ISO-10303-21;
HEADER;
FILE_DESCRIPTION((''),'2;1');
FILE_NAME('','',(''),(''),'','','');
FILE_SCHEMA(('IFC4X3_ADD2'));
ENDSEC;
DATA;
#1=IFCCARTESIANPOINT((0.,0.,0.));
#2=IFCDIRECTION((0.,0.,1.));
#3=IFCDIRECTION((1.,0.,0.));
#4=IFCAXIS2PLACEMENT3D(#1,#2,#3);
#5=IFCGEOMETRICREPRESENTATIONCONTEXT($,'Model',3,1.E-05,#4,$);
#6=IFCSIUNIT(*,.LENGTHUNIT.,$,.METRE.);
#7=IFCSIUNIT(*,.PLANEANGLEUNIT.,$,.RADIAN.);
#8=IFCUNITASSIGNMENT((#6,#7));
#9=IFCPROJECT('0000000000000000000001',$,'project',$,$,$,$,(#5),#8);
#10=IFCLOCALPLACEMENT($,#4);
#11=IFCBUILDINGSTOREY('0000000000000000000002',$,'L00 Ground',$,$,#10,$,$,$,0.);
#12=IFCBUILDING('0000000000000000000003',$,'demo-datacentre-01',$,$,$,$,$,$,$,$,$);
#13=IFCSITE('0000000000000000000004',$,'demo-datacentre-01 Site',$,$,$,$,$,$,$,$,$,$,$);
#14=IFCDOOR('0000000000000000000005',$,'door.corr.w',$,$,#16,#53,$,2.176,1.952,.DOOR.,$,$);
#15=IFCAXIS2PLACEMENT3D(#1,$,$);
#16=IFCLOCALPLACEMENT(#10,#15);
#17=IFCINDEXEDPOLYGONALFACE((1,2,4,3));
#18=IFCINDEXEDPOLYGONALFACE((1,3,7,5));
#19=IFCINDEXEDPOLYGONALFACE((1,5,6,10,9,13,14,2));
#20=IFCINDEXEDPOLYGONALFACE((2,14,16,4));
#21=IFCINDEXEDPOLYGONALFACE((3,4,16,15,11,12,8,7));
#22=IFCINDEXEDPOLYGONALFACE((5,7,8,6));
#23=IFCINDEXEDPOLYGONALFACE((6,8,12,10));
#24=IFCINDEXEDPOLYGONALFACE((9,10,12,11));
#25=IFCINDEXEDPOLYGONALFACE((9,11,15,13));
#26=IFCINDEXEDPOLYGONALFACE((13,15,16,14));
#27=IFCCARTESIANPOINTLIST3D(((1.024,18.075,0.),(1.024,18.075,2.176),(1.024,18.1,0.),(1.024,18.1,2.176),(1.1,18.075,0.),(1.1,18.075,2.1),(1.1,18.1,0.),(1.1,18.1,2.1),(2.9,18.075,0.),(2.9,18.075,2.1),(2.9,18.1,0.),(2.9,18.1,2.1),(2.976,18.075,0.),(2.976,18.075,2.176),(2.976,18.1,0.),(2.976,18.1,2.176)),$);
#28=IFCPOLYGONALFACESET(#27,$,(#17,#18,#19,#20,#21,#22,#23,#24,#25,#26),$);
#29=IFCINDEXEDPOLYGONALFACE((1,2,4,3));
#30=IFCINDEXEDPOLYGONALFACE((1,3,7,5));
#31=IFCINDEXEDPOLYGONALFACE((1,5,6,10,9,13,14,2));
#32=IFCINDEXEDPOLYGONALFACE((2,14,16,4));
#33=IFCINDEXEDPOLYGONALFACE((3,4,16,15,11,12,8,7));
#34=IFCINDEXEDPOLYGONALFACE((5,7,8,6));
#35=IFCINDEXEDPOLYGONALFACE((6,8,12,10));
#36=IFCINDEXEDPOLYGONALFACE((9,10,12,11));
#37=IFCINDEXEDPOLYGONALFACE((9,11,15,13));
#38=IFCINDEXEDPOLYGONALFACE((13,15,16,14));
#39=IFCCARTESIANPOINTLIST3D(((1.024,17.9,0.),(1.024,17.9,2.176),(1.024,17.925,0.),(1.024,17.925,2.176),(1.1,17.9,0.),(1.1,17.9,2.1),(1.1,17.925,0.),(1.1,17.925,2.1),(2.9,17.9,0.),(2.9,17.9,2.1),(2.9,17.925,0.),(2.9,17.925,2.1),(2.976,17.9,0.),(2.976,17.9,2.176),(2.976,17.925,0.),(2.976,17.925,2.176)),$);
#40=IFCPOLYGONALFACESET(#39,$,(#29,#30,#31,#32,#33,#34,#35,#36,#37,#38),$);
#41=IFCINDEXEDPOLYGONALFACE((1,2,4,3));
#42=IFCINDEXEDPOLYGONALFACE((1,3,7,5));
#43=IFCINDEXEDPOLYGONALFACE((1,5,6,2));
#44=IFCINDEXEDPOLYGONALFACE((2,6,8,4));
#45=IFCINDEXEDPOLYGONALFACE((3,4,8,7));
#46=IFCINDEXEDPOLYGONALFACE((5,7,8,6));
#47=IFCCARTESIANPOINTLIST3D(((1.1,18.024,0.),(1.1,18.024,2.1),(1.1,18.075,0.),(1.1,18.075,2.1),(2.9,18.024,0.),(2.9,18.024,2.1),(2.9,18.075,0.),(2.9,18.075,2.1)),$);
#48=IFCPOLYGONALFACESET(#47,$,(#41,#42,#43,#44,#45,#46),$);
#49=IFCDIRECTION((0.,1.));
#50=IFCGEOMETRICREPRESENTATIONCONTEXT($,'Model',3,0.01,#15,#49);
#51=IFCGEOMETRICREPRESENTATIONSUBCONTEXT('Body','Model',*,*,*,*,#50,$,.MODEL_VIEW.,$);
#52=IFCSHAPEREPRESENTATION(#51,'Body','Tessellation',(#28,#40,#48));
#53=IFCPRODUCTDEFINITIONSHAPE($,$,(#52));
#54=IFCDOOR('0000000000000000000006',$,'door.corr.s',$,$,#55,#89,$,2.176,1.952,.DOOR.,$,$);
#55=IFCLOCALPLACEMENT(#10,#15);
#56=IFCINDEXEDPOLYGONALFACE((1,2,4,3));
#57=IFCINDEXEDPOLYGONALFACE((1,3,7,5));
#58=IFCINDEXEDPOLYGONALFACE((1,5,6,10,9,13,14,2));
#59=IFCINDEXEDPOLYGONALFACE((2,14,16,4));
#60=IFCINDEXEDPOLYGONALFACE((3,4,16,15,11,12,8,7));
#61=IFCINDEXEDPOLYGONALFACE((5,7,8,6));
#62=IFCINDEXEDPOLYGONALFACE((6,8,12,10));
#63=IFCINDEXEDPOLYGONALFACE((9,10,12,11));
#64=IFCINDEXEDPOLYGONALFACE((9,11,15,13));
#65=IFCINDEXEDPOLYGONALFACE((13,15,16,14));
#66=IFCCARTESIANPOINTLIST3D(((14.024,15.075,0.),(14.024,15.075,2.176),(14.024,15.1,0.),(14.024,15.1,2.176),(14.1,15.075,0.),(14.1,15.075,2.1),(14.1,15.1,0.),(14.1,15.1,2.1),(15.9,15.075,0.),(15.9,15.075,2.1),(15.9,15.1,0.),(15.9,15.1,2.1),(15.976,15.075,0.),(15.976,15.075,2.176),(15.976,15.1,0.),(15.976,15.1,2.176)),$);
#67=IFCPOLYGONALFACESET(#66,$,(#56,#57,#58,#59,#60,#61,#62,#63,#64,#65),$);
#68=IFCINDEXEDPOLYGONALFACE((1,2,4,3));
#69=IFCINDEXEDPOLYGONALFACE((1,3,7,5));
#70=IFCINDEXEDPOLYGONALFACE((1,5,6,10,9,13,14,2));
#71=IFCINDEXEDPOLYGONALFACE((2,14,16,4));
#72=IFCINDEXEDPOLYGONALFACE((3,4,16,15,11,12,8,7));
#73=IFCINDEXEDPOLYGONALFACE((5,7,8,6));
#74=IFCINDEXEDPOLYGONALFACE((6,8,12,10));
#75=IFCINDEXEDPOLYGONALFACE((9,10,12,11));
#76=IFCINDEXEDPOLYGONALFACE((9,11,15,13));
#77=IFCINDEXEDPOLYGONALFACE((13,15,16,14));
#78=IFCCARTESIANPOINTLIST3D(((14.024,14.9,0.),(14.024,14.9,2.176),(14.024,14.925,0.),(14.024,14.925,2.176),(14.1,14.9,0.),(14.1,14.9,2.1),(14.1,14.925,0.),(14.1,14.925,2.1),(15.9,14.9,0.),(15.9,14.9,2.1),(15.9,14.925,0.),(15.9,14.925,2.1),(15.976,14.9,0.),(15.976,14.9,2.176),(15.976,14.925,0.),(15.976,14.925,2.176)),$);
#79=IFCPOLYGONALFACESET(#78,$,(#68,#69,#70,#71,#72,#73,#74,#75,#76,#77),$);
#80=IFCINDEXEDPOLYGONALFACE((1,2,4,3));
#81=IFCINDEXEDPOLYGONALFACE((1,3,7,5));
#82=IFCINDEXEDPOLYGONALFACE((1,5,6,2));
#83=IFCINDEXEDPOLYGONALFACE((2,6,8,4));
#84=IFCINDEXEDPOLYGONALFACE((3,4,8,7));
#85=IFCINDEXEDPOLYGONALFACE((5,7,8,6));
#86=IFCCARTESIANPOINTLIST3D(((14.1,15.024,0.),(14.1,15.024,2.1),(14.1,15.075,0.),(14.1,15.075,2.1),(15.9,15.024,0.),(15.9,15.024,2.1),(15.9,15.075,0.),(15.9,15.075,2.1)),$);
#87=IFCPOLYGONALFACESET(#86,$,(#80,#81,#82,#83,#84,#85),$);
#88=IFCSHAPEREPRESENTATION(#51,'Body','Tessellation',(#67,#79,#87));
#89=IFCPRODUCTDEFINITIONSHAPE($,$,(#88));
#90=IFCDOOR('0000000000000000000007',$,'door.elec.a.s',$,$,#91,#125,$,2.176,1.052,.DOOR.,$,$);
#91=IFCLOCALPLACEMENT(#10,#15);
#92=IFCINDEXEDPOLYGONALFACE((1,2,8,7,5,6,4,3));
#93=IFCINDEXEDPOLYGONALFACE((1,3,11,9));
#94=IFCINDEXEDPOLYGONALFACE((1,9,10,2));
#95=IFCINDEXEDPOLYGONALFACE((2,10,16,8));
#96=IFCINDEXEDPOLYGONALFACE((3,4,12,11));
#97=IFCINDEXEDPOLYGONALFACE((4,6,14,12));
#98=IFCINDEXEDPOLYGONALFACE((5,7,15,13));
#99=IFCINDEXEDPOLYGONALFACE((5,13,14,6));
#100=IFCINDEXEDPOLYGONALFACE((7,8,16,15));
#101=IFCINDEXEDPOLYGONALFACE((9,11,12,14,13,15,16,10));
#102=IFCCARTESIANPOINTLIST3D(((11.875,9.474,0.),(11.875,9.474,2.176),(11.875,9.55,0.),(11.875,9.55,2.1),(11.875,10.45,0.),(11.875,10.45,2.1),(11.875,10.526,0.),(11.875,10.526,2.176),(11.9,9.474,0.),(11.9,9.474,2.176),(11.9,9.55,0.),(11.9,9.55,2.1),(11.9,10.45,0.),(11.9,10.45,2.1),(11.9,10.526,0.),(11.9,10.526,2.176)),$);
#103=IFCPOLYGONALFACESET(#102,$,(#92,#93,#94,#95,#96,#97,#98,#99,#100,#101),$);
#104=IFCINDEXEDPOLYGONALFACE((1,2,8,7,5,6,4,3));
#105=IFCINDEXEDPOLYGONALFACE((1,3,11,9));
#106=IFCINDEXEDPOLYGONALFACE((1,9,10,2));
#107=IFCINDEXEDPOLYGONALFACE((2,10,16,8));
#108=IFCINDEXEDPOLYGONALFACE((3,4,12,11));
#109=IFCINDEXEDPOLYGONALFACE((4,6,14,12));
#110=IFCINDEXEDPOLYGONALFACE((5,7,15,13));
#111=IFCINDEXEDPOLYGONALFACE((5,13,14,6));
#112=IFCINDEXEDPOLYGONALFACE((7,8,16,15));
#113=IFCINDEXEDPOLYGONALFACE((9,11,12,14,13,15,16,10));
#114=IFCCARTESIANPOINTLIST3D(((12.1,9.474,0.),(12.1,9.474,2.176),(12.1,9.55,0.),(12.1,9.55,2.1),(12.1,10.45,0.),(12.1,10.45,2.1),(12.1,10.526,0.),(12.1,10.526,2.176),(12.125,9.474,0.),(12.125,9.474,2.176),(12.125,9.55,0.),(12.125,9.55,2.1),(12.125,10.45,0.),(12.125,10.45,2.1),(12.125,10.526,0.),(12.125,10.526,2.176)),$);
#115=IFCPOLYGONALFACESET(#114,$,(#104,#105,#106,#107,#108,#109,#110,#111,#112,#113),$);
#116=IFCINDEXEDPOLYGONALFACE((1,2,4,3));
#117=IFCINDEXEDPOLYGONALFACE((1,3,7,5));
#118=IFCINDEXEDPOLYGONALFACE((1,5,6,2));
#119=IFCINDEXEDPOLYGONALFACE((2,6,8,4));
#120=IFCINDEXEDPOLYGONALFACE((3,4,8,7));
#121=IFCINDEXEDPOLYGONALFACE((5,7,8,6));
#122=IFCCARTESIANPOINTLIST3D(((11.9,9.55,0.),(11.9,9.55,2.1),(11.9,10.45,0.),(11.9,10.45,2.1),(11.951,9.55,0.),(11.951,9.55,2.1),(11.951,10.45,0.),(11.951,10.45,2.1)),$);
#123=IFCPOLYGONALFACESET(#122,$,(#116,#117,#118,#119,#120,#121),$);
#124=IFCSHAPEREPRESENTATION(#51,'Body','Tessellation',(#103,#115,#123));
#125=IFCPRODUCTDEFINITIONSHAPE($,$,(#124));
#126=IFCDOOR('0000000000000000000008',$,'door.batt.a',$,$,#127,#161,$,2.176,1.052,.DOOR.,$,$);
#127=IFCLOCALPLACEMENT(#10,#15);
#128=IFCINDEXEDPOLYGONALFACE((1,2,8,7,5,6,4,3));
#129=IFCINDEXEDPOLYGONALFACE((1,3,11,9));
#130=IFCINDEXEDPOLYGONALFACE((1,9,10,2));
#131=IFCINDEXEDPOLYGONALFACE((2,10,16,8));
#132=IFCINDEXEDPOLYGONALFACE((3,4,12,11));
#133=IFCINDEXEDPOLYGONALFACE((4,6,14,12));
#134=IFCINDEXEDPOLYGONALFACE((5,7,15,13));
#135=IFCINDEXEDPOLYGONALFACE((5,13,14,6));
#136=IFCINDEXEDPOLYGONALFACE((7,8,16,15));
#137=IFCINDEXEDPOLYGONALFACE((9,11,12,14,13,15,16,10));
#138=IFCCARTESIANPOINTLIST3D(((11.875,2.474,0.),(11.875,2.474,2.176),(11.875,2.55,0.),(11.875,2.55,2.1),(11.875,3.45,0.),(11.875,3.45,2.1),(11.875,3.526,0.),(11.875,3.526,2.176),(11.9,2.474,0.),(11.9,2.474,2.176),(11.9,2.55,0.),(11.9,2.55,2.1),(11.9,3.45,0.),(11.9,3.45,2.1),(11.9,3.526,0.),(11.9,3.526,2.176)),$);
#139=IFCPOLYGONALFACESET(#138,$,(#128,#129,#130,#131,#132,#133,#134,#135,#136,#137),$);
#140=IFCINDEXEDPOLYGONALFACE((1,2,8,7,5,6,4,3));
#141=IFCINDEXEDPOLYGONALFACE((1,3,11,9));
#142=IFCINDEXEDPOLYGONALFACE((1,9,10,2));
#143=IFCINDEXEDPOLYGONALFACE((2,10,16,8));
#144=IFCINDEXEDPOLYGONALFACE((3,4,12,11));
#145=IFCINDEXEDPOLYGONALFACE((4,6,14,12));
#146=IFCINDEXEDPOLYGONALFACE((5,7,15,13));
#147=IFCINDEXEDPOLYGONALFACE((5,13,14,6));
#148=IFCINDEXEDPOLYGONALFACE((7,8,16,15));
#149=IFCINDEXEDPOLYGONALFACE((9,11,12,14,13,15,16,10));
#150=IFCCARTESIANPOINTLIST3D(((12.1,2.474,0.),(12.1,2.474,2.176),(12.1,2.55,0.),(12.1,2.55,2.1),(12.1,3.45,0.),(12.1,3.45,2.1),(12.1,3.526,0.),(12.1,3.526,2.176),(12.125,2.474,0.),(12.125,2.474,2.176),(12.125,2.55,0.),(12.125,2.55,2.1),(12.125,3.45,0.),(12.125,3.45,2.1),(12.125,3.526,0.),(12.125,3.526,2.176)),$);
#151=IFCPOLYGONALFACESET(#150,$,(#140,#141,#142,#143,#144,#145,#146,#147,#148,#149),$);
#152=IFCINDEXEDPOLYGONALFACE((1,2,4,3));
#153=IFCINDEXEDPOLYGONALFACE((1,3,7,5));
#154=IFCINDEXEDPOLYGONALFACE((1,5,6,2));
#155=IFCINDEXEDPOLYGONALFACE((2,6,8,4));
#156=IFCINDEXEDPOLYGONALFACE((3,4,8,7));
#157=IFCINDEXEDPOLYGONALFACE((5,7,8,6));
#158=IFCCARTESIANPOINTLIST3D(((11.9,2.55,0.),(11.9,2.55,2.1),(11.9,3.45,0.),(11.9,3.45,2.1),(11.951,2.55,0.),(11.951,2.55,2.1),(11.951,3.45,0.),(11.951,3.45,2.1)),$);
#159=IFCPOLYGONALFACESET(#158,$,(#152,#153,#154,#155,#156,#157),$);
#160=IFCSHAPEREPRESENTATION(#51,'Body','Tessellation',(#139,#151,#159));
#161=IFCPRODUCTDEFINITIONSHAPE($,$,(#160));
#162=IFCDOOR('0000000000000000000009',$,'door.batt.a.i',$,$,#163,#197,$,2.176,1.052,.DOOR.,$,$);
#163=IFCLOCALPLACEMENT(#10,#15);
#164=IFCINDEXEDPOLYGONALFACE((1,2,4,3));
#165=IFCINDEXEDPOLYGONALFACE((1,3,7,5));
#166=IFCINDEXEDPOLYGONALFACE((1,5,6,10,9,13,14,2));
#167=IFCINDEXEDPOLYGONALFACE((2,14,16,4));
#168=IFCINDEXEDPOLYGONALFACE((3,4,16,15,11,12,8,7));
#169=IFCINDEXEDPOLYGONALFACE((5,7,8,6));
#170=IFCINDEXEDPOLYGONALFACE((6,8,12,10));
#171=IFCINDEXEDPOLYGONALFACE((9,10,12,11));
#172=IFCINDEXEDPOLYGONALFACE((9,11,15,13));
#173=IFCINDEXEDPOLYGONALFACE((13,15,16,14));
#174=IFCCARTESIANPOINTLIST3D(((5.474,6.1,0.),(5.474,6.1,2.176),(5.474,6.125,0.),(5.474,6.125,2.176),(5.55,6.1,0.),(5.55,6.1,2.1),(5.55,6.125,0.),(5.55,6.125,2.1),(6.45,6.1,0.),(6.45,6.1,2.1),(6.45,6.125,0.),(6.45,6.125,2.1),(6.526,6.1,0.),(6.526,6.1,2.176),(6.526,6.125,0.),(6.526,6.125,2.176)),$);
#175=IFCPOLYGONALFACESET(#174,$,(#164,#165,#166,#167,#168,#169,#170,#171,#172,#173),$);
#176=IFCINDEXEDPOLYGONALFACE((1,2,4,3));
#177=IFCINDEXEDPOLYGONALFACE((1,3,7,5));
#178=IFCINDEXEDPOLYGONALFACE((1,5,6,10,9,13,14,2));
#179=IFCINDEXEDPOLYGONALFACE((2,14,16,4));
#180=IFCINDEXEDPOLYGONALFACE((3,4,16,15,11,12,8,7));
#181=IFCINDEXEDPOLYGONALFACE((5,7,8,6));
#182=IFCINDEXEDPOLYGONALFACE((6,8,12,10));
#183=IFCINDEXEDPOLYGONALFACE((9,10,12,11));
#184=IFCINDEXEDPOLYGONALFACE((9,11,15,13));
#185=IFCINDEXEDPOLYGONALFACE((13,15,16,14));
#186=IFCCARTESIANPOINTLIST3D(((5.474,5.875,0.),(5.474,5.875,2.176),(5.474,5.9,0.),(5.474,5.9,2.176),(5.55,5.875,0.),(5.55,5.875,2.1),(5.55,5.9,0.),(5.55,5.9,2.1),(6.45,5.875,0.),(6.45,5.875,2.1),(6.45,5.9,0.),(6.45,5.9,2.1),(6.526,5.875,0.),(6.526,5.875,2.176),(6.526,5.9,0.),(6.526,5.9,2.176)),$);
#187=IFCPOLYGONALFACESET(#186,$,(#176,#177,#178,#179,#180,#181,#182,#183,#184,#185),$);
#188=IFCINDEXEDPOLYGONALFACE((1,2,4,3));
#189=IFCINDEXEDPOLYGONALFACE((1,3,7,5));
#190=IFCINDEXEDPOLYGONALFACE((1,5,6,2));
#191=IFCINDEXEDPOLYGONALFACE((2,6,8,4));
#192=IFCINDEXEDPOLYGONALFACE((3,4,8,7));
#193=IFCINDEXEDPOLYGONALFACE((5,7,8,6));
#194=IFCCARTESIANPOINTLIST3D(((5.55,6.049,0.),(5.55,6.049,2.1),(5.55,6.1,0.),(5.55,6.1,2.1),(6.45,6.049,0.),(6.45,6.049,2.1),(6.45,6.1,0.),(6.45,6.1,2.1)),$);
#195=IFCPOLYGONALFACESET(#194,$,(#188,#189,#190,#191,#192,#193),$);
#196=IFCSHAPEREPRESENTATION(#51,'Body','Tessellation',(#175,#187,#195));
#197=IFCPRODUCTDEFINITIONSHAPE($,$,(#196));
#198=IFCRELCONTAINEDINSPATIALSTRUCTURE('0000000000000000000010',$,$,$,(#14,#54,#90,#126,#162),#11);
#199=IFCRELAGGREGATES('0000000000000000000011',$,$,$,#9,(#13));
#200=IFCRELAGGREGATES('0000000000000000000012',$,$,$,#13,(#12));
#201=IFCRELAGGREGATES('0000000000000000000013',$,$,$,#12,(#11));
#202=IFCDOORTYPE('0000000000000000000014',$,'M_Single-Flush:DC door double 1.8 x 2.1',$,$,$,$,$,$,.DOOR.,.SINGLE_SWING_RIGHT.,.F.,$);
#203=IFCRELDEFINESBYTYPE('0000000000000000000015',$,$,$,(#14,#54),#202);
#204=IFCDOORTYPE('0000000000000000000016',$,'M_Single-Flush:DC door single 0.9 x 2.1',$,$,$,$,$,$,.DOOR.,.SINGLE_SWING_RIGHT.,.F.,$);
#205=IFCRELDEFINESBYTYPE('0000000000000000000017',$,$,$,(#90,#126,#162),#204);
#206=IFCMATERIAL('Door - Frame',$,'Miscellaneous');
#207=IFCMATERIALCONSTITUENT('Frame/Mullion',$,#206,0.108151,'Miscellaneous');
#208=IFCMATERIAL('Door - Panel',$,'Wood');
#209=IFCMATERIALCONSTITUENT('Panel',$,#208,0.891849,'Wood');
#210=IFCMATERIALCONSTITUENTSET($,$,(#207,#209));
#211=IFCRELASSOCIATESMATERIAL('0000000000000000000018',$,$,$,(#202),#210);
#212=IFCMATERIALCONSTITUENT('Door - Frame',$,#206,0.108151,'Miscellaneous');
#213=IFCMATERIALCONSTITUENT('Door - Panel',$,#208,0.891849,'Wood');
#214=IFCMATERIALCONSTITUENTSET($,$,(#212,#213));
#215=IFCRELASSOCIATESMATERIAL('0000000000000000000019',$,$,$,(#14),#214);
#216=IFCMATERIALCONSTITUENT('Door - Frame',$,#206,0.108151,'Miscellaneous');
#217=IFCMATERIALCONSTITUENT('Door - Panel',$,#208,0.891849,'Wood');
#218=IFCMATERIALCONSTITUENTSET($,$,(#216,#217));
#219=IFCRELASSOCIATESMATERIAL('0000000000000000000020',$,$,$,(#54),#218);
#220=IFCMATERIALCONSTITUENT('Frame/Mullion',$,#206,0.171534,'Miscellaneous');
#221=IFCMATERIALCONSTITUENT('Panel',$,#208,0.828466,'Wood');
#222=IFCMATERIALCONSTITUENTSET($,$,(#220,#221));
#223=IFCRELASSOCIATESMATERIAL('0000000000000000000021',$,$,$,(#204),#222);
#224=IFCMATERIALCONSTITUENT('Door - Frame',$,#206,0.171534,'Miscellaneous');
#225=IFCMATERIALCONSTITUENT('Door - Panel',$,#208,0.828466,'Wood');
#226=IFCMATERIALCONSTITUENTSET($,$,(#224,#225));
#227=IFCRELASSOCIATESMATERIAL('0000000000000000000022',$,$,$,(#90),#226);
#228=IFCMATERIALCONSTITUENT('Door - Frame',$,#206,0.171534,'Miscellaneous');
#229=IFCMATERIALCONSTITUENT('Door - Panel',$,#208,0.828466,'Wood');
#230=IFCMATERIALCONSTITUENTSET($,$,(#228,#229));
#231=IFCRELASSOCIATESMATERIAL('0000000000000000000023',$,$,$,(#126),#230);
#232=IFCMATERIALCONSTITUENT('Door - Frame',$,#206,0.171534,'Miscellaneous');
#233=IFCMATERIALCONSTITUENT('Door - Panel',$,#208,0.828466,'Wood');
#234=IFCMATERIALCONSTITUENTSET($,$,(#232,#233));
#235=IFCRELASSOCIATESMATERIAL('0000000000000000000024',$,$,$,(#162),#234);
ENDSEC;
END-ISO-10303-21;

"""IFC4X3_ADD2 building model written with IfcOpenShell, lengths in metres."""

from ifc_helpers import new_model, si_unit, direction, frame, frame_2d, origin, origin_with_axes, place, context, subcontext, project, spatial, polyline, rectangle, outline, extrude, source, transform, mapped, material, constituent, constituent_set, type_object, type_shapes, element, save


model = new_model("IFC4X3_ADD2")

# Units and contexts
model_context_1 = context("Model", 3, precision=0.01, world=origin(), true_north=direction((0.0, 1.0)))
model_context_2 = context("Model", 3, precision=1e-05, world=origin_with_axes())
body_context = subcontext(model_context_1, "Body", "Model", "MODEL_VIEW")
ifc_project = project(units=[si_unit("LENGTHUNIT", "METRE"), si_unit("PLANEANGLEUNIT", "RADIAN")], contexts=[model_context_2])

# Site, building, storey
site = spatial("IfcSite", under=ifc_project, Name="demo-datacentre-01 Site")
building = spatial("IfcBuilding", under=site, Name="demo-datacentre-01")
storey_placement = place(None, origin_with_axes())
storey = spatial("IfcBuildingStorey", under=building, at=storey_placement, Name="L00 Ground", Elevation=0.0)

# Shared definitions
placement_1 = place(None, origin())
placement_2 = place(placement_1, origin())
placement_3 = place(placement_2, origin())

# Doors
ifc_material_1 = material(Name="Door - Frame", Category="Miscellaneous")
ifc_material_2 = material(Name="Door - Panel", Category="Wood")
ifc_constituent_1 = constituent(ifc_material_1, Name="Door - Frame", Category="Miscellaneous", fraction=0.108151)
ifc_constituent_2 = constituent(ifc_material_2, Name="Door - Panel", Category="Wood", fraction=0.891849)
ifc_constituent_set_1 = constituent_set(constituents=[ifc_constituent_1, ifc_constituent_2])
ifc_constituent_3 = constituent(ifc_material_1, Name="Frame/Mullion", Category="Miscellaneous", fraction=0.108151)
ifc_constituent_4 = constituent(ifc_material_2, Name="Panel", Category="Wood", fraction=0.891849)
ifc_constituent_set_2 = constituent_set(constituents=[ifc_constituent_3, ifc_constituent_4])
door_type_1 = type_object("IfcDoorType", Name="M_Single-Flush:DC door double 1.8 x 2.1", OperationType="SINGLE_SWING_RIGHT", ParameterTakesPrecedence=False, PredefinedType="DOOR", material=ifc_constituent_set_2)
shared_shape_1 = source(origin(), body_context, "Body", "SweptSolid", [
    extrude(outline(polyline([(-0.976, -1.107), (0.976, -1.107), (0.976, 1.069), (0.9, 1.069), (0.9, -1.031), (-0.9, -1.031), (-0.9, 1.069), (-0.976, 1.069), (-0.976, -1.107)])), frame((0.9, 0.15, 1.069), z_axis=(0.0, 1.0, 0.0), x_axis=(1.0, 0.0, 0.0)), (0.0, 0.0, 1.0), 0.025),
    extrude(outline(polyline([(-1.107, -0.976), (1.069, -0.976), (1.069, -0.9), (-1.031, -0.9), (-1.031, 0.9), (1.069, 0.9), (1.069, 0.976), (-1.107, 0.976), (-1.107, -0.976)])), frame((0.9, -0.025, 1.069), z_axis=(0.0, 1.0, 0.0), x_axis=(0.0, 0.0, -1.0)), (0.0, 0.0, 1.0), 0.025),
    extrude(rectangle(XDim=0.051, YDim=1.8, at=frame_2d((0.0, 0.0), x_axis=(1.0, 0.0))), frame((0.9, 0.1245, 0.0), z_axis=(0.0, 0.0, 1.0), x_axis=(0.0, 1.0, 0.0)), (0.0, 0.0, 1.0), 2.1),
])
type_shapes(door_type_1, [shared_shape_1])
door_1_placement = place(placement_3, frame((1.1, 17.925, 0.0)))
element("IfcDoor", 1, at=door_1_placement, inside=storey, type_object=door_type_1, material=ifc_constituent_set_1, Name="door.corr.w", OverallHeight=2.176, OverallWidth=1.952, PredefinedType="DOOR", context=body_context, shape_type="MappedRepresentation", body=[
    mapped(shared_shape_1, transform((0.0, 0.0, 0.0), scale=1.0)),
])
ifc_constituent_5 = constituent(ifc_material_1, Name="Door - Frame", Category="Miscellaneous", fraction=0.108151)
ifc_constituent_6 = constituent(ifc_material_2, Name="Door - Panel", Category="Wood", fraction=0.891849)
ifc_constituent_set_3 = constituent_set(constituents=[ifc_constituent_5, ifc_constituent_6])
door_2_placement = place(placement_3, frame((14.1, 14.925, 0.0)))
element("IfcDoor", 2, at=door_2_placement, inside=storey, type_object=door_type_1, material=ifc_constituent_set_3, Name="door.corr.s", OverallHeight=2.176, OverallWidth=1.952, PredefinedType="DOOR", context=body_context, shape_type="MappedRepresentation", body=[
    mapped(shared_shape_1, transform((0.0, 0.0, 0.0), scale=1.0)),
])
ifc_constituent_7 = constituent(ifc_material_1, Name="Door - Frame", Category="Miscellaneous", fraction=0.171534)
ifc_constituent_8 = constituent(ifc_material_2, Name="Door - Panel", Category="Wood", fraction=0.828466)
ifc_constituent_set_4 = constituent_set(constituents=[ifc_constituent_7, ifc_constituent_8])
ifc_constituent_9 = constituent(ifc_material_1, Name="Frame/Mullion", Category="Miscellaneous", fraction=0.171534)
ifc_constituent_10 = constituent(ifc_material_2, Name="Panel", Category="Wood", fraction=0.828466)
ifc_constituent_set_5 = constituent_set(constituents=[ifc_constituent_9, ifc_constituent_10])
door_type_2 = type_object("IfcDoorType", Name="M_Single-Flush:DC door single 0.9 x 2.1", OperationType="SINGLE_SWING_RIGHT", ParameterTakesPrecedence=False, PredefinedType="DOOR", material=ifc_constituent_set_5)
shared_shape_2 = source(origin(), body_context, "Body", "SweptSolid", [
    extrude(outline(polyline([(-0.526, -1.107), (0.526, -1.107), (0.526, 1.069), (0.45, 1.069), (0.45, -1.031), (-0.45, -1.031), (-0.45, 1.069), (-0.526, 1.069), (-0.526, -1.107)])), frame((0.45, 0.2, 1.069), z_axis=(0.0, 1.0, 0.0), x_axis=(1.0, 0.0, 0.0)), (0.0, 0.0, 1.0), 0.025),
    extrude(outline(polyline([(-1.107, -0.526), (1.069, -0.526), (1.069, -0.45), (-1.031, -0.45), (-1.031, 0.45), (1.069, 0.45), (1.069, 0.526), (-1.107, 0.526), (-1.107, -0.526)])), frame((0.45, -0.025, 1.069), z_axis=(0.0, 1.0, 0.0), x_axis=(0.0, 0.0, -1.0)), (0.0, 0.0, 1.0), 0.025),
    extrude(rectangle(XDim=0.051, YDim=0.9, at=frame_2d((0.0, 0.0), x_axis=(1.0, 0.0))), frame((0.45, 0.1745, 0.0), z_axis=(0.0, 0.0, 1.0), x_axis=(0.0, 1.0, 0.0)), (0.0, 0.0, 1.0), 2.1),
])
type_shapes(door_type_2, [shared_shape_2])
door_3_placement = place(placement_3, frame((12.1, 9.55, 0.0), z_axis=(0.0, 0.0, 1.0), x_axis=(0.0, 1.0, 0.0)))
element("IfcDoor", 3, at=door_3_placement, inside=storey, type_object=door_type_2, material=ifc_constituent_set_4, Name="door.elec.a.s", OverallHeight=2.176, OverallWidth=1.052, PredefinedType="DOOR", context=body_context, shape_type="MappedRepresentation", body=[
    mapped(shared_shape_2, transform((0.0, 0.0, 0.0), scale=1.0)),
])
ifc_constituent_11 = constituent(ifc_material_1, Name="Door - Frame", Category="Miscellaneous", fraction=0.171534)
ifc_constituent_12 = constituent(ifc_material_2, Name="Door - Panel", Category="Wood", fraction=0.828466)
ifc_constituent_set_6 = constituent_set(constituents=[ifc_constituent_11, ifc_constituent_12])
door_4_placement = place(placement_3, frame((12.1, 2.55, 0.0), z_axis=(0.0, 0.0, 1.0), x_axis=(0.0, 1.0, 0.0)))
element("IfcDoor", 4, at=door_4_placement, inside=storey, type_object=door_type_2, material=ifc_constituent_set_6, Name="door.batt.a", OverallHeight=2.176, OverallWidth=1.052, PredefinedType="DOOR", context=body_context, shape_type="MappedRepresentation", body=[
    mapped(shared_shape_2, transform((0.0, 0.0, 0.0), scale=1.0)),
])
ifc_constituent_13 = constituent(ifc_material_1, Name="Door - Frame", Category="Miscellaneous", fraction=0.171534)
ifc_constituent_14 = constituent(ifc_material_2, Name="Door - Panel", Category="Wood", fraction=0.828466)
ifc_constituent_set_7 = constituent_set(constituents=[ifc_constituent_13, ifc_constituent_14])
door_5_placement = place(placement_3, frame((5.55, 5.9, 0.0)))
element("IfcDoor", 5, at=door_5_placement, inside=storey, type_object=door_type_2, material=ifc_constituent_set_7, Name="door.batt.a.i", OverallHeight=2.176, OverallWidth=1.052, PredefinedType="DOOR", context=body_context, shape_type="MappedRepresentation", body=[
    mapped(shared_shape_2, transform((0.0, 0.0, 0.0), scale=1.0)),
])

save(model, "model.ifc")
